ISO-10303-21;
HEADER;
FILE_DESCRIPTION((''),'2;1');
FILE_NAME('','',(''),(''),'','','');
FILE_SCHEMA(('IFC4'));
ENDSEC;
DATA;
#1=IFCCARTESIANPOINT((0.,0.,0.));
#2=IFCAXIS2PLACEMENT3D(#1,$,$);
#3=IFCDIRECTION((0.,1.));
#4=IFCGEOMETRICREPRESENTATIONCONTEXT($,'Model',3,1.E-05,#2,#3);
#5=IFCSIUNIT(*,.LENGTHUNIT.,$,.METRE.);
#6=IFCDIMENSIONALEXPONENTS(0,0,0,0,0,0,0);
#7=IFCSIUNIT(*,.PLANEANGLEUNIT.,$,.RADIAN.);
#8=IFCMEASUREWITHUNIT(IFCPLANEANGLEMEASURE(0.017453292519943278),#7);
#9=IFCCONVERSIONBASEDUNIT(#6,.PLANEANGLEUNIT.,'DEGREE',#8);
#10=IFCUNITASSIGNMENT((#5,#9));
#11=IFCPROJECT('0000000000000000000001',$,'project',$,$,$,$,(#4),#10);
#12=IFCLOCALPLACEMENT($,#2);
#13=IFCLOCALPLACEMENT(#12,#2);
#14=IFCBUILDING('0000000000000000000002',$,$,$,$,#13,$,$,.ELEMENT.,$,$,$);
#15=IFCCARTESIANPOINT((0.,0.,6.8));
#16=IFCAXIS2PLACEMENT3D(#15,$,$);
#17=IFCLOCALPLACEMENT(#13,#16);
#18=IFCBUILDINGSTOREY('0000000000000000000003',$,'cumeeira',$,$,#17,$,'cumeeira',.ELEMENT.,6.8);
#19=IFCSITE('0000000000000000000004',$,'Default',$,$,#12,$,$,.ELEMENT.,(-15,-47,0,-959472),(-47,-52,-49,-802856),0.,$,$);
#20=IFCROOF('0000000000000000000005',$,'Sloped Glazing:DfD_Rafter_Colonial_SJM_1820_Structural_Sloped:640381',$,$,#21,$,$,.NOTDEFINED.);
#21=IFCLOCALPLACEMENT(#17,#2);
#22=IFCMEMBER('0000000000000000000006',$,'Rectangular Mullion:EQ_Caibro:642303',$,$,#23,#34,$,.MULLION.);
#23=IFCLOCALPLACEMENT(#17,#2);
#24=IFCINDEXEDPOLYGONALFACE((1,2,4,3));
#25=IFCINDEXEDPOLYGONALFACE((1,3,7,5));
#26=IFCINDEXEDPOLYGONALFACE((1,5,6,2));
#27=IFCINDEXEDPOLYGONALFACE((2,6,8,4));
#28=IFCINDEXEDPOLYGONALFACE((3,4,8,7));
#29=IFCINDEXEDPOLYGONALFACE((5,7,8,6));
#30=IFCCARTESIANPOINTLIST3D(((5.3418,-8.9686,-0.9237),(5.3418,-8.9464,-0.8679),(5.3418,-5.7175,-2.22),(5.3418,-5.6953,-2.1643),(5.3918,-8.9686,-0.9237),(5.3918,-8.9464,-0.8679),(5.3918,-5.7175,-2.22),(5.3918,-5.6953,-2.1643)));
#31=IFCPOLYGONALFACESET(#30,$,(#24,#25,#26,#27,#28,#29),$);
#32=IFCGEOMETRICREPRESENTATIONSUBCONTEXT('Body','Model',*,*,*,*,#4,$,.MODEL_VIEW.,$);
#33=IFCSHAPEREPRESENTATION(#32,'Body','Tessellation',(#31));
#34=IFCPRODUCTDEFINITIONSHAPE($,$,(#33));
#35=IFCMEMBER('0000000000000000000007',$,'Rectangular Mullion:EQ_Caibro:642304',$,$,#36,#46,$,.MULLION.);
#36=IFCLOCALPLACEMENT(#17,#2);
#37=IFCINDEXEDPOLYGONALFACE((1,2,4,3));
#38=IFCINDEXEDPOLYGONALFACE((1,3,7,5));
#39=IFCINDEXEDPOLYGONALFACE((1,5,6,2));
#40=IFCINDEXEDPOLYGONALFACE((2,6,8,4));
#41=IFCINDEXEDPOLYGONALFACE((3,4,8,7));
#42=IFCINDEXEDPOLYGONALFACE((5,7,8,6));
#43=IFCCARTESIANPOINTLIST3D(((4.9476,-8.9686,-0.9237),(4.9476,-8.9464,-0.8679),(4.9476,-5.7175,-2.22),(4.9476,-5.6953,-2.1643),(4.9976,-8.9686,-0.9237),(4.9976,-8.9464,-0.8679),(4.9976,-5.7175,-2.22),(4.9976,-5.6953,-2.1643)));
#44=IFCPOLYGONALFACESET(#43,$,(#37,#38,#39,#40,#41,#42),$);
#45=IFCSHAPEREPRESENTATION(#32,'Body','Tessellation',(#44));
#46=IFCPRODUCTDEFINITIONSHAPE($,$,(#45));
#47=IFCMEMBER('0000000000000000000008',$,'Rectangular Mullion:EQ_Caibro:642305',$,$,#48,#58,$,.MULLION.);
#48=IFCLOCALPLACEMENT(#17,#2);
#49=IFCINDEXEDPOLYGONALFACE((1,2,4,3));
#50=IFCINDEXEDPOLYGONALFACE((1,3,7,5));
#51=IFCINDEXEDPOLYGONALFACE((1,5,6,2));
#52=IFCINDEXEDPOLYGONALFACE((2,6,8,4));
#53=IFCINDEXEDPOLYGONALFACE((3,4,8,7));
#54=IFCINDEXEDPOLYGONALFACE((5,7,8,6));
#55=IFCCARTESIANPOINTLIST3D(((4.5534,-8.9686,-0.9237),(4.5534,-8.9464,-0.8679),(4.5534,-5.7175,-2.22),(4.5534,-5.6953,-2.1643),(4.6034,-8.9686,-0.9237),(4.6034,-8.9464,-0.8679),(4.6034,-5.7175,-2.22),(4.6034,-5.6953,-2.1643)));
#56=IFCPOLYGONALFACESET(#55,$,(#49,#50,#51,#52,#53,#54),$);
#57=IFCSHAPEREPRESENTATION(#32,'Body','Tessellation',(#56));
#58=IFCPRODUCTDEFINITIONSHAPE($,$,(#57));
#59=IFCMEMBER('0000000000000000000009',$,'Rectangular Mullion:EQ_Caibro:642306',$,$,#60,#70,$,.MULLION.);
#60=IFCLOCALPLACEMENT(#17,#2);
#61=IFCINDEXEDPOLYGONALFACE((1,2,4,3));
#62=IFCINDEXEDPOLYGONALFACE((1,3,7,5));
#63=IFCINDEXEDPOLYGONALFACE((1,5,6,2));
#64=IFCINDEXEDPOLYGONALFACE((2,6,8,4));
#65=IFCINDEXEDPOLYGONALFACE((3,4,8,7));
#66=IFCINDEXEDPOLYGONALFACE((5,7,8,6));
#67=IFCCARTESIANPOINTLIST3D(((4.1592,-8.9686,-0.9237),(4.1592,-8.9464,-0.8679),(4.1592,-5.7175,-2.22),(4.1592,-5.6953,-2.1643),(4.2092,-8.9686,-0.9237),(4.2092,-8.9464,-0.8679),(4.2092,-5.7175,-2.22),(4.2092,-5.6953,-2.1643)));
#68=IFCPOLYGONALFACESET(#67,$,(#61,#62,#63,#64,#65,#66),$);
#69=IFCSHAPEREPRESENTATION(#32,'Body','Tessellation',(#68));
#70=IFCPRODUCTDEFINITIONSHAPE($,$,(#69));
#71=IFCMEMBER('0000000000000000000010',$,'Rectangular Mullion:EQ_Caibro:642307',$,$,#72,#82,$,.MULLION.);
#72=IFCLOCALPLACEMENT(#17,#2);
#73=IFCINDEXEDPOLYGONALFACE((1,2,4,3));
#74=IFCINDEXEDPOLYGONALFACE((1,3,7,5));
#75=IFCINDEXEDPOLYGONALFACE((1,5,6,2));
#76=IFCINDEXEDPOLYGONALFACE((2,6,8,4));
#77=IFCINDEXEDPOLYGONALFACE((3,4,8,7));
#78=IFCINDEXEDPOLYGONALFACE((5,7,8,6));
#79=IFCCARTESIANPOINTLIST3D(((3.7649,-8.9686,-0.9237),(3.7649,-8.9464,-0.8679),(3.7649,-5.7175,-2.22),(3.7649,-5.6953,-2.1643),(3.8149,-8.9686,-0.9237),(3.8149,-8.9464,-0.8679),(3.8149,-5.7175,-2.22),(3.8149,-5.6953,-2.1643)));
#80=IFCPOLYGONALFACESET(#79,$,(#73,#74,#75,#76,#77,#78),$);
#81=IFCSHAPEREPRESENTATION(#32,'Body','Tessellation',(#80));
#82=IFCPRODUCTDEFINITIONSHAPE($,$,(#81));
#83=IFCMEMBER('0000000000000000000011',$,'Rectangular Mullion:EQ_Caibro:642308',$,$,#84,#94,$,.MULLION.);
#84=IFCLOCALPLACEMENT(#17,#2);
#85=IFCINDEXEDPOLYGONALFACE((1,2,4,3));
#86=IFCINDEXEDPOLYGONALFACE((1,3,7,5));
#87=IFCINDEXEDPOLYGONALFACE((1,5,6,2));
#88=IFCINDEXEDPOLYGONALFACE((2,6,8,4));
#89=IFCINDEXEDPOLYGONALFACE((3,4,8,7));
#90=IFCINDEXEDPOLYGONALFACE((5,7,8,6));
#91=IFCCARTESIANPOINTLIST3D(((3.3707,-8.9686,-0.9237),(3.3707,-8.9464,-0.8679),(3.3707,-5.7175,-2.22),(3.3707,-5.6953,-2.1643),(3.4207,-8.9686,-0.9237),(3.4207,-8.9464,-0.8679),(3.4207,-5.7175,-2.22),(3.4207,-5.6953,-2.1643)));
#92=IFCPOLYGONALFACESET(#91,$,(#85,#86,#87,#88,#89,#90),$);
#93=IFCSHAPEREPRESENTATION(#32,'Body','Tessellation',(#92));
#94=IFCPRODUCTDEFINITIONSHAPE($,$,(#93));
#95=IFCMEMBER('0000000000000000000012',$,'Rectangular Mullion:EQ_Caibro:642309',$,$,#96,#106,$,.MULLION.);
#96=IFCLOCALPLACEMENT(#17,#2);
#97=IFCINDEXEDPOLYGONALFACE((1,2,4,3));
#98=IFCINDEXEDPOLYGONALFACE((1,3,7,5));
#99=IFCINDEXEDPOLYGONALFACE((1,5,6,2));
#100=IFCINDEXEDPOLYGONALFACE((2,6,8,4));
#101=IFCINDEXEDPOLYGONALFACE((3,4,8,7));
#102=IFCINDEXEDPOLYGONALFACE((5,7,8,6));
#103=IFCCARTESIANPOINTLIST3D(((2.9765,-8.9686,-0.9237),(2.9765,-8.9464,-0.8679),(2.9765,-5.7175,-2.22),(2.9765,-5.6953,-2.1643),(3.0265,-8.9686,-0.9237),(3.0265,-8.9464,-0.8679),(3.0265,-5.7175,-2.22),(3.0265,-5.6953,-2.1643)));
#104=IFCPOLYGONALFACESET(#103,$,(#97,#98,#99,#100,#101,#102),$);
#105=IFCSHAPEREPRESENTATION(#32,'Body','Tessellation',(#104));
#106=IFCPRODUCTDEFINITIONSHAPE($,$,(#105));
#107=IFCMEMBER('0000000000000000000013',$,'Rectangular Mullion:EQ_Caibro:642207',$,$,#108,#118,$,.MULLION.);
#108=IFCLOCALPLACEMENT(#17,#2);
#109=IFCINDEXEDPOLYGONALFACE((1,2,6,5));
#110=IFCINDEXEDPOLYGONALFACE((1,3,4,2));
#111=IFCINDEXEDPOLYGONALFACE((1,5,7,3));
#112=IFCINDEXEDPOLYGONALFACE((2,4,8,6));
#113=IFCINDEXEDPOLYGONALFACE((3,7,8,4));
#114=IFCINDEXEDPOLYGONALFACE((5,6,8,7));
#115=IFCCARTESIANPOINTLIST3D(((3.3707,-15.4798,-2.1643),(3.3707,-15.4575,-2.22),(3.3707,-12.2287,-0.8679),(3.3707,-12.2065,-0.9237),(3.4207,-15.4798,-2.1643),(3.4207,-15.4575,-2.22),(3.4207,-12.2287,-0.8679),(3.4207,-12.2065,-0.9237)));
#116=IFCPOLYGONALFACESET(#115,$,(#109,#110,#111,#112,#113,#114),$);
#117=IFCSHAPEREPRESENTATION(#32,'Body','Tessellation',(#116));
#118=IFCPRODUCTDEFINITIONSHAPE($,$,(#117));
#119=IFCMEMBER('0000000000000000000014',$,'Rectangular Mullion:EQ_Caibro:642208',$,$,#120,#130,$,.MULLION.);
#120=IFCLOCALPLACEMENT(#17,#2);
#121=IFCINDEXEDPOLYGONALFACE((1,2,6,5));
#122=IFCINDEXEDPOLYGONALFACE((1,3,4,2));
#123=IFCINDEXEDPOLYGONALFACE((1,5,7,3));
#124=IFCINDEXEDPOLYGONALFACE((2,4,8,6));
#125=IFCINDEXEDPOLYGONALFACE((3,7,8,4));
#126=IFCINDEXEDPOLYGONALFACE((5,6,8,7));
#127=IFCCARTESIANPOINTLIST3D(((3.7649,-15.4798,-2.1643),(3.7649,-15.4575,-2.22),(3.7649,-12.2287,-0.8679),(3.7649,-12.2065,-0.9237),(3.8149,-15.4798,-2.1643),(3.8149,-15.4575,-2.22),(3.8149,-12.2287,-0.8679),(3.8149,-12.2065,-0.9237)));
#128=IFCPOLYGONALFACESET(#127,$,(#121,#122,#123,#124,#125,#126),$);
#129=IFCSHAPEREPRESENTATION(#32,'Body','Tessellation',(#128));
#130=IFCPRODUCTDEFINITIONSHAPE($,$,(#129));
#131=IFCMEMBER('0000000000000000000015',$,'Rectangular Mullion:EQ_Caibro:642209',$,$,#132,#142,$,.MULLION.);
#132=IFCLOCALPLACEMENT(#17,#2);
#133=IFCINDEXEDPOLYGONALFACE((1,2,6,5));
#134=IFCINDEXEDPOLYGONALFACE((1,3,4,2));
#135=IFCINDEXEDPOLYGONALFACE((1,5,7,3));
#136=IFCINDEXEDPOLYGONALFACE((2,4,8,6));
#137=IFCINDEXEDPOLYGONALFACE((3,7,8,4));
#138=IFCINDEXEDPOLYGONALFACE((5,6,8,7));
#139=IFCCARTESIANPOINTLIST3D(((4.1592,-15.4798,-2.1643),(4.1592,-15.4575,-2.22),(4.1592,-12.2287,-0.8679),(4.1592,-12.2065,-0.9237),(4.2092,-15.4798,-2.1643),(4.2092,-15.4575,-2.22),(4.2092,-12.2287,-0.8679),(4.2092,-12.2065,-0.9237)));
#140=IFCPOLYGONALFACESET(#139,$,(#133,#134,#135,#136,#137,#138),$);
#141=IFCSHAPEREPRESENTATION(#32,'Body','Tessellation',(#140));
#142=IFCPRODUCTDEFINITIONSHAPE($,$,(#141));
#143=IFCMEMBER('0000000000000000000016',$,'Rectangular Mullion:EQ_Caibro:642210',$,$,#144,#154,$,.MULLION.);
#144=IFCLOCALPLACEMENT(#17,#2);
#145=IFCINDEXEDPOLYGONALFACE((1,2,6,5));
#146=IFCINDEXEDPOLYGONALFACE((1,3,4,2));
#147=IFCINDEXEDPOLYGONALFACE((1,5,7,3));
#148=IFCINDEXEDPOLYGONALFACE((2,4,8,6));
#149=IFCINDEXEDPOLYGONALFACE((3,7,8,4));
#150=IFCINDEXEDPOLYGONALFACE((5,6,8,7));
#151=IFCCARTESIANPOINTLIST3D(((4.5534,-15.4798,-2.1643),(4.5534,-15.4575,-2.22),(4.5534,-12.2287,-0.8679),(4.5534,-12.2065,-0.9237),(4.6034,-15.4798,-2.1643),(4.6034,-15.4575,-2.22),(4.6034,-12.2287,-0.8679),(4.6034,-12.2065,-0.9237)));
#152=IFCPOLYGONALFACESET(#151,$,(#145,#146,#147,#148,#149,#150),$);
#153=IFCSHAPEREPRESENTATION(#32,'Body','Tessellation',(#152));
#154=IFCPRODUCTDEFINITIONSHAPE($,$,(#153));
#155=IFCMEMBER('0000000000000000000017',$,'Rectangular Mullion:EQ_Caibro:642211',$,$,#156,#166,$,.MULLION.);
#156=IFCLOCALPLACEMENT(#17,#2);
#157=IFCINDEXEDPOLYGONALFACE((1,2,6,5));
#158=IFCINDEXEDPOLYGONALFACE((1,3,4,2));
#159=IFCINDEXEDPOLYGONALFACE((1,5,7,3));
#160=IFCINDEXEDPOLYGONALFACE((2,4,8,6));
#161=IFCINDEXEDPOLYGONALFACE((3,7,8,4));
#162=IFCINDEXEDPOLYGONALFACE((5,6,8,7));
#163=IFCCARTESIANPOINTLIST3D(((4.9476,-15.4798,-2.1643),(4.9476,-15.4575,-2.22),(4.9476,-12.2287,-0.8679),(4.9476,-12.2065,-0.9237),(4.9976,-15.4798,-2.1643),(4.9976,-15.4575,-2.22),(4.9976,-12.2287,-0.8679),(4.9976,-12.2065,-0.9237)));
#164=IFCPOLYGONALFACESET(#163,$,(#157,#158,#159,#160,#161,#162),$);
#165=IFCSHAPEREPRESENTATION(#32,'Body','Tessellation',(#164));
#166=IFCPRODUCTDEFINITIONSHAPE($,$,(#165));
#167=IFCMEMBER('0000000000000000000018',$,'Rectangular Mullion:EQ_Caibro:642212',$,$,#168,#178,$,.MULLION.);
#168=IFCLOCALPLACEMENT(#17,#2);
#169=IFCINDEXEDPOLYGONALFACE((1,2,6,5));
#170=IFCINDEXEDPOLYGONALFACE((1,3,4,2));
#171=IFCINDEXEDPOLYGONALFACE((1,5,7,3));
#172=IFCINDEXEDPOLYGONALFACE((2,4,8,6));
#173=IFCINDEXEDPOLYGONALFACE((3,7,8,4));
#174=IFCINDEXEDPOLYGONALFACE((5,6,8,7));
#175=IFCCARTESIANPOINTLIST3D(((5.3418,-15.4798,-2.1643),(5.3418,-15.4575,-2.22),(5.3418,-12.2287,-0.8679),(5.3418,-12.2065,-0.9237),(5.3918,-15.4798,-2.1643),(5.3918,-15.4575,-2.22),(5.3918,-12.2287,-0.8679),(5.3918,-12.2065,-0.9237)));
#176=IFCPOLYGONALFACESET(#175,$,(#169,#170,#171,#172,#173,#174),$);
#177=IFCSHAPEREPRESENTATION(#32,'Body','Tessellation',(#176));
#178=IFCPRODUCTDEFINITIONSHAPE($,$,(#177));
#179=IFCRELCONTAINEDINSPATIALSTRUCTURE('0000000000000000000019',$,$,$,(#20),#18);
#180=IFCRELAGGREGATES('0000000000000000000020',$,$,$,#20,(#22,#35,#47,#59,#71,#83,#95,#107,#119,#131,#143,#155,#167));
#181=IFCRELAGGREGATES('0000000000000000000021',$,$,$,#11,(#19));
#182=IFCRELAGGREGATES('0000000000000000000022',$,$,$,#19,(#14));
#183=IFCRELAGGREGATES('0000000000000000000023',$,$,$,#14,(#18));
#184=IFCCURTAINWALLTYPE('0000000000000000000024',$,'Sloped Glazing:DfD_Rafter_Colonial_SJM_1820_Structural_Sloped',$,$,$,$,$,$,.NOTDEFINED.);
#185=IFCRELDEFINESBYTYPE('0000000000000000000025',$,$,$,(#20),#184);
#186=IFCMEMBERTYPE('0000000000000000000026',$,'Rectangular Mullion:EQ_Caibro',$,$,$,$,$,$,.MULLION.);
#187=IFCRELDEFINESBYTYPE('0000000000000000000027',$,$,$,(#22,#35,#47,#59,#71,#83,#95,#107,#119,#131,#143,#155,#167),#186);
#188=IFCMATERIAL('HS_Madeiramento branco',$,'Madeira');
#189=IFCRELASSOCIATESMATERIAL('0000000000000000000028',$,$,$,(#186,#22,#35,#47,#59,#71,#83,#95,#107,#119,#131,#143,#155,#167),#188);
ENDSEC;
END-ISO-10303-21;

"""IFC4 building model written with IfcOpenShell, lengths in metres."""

from ifc_helpers import new_model, entity, si_unit, converted_unit, direction, frame, origin, place, context, subcontext, project, spatial, indexed_curve, outline, extrude, source, transform, mapped, material, type_object, type_shapes, element, aggregate, save


model = new_model("IFC4")

# Units and contexts
model_context = context("Model", 3, precision=1e-05, world=origin(), true_north=direction((0.0, 1.0)))
body_context = subcontext(model_context, "Body", "Model", "MODEL_VIEW")
ifc_project = project(units=[si_unit("LENGTHUNIT", "METRE"), converted_unit("PLANEANGLEUNIT", "DEGREE", entity("IfcPlaneAngleMeasure", 0.017453292519943278), si_unit("PLANEANGLEUNIT", "RADIAN"), dimensions=[0, 0, 0, 0, 0, 0, 0])], contexts=[model_context])

# Site, building, storey
site_placement = place(None, origin())
site = spatial("IfcSite", under=ifc_project, at=site_placement, Name="Default", CompositionType="ELEMENT", RefLatitude=(-15, -47, 0, -959472), RefLongitude=(-47, -52, -49, -802856), RefElevation=0.0)
building_placement = place(site_placement, origin())
building = spatial("IfcBuilding", under=site, at=building_placement, CompositionType="ELEMENT")
storey_placement = place(building_placement, frame((0.0, 0.0, 6.8)))
storey = spatial("IfcBuildingStorey", under=building, at=storey_placement, Name="cumeeira", LongName="cumeeira", CompositionType="ELEMENT", Elevation=6.8)

# Roof, members
curtain_wall_type = type_object("IfcCurtainWallType", Name="Sloped Glazing:DfD_Rafter_Colonial_SJM_1820_Structural_Sloped", PredefinedType="NOTDEFINED")
roof_placement = place(storey_placement, frame((0.0, 0.0, -6.8)))
roof = element("IfcRoof", 1, at=roof_placement, inside=storey, type_object=curtain_wall_type, Name="Sloped Glazing:DfD_Rafter_Colonial_SJM_1820_Structural_Sloped:640381", PredefinedType="NOTDEFINED")
ifc_material = material(Name="HS_Madeiramento branco", Category="Madeira")
member_type_1 = type_object("IfcMemberType", Name="Rectangular Mullion:EQ_Caibro", PredefinedType="MULLION", material=ifc_material)
shared_shape_1 = source(origin(), body_context, "Body", "SweptSolid", [
    extrude(outline(indexed_curve([(-0.025, -0.03), (0.025, -0.03), (0.025, 0.03), (-0.025, 0.03), (-0.025, -0.03)], self_intersect=False)), frame((0.0, -0.03, -3.5), z_axis=(0.0, 0.0, 1.0), x_axis=(-1.0, 0.0, 0.0)), (0.0, 0.0, 1.0), 3.5),
])
type_shapes(member_type_1, [shared_shape_1])
member_1_placement = place(roof_placement, frame((5.3668, -8.9686, 5.8763), z_axis=(0.0, -0.928878, 0.370385), x_axis=(-1.0, 0.0, 0.0)))
member_1 = element("IfcMember", 2, at=member_1_placement, type_object=member_type_1, material=ifc_material, Name="Rectangular Mullion:EQ_Caibro:642303", PredefinedType="MULLION", context=body_context, shape_type="MappedRepresentation", body=[
    mapped(shared_shape_1, transform((0.0, 0.0, 0.0), scale=1.0)),
])
member_2_placement = place(roof_placement, frame((4.9726, -8.9686, 5.8763), z_axis=(0.0, -0.928878, 0.370385), x_axis=(-1.0, 0.0, 0.0)))
member_2 = element("IfcMember", 3, at=member_2_placement, type_object=member_type_1, material=ifc_material, Name="Rectangular Mullion:EQ_Caibro:642304", PredefinedType="MULLION", context=body_context, shape_type="MappedRepresentation", body=[
    mapped(shared_shape_1, transform((0.0, 0.0, 0.0), scale=1.0)),
])
member_3_placement = place(roof_placement, frame((4.5784, -8.9686, 5.8763), z_axis=(0.0, -0.928878, 0.370385), x_axis=(-1.0, 0.0, 0.0)))
member_3 = element("IfcMember", 4, at=member_3_placement, type_object=member_type_1, material=ifc_material, Name="Rectangular Mullion:EQ_Caibro:642305", PredefinedType="MULLION", context=body_context, shape_type="MappedRepresentation", body=[
    mapped(shared_shape_1, transform((0.0, 0.0, 0.0), scale=1.0)),
])
member_4_placement = place(roof_placement, frame((4.1842, -8.9686, 5.8763), z_axis=(0.0, -0.928878, 0.370385), x_axis=(-1.0, 0.0, 0.0)))
member_4 = element("IfcMember", 5, at=member_4_placement, type_object=member_type_1, material=ifc_material, Name="Rectangular Mullion:EQ_Caibro:642306", PredefinedType="MULLION", context=body_context, shape_type="MappedRepresentation", body=[
    mapped(shared_shape_1, transform((0.0, 0.0, 0.0), scale=1.0)),
])
member_5_placement = place(roof_placement, frame((3.7899, -8.9686, 5.8763), z_axis=(0.0, -0.928878, 0.370385), x_axis=(-1.0, 0.0, 0.0)))
member_5 = element("IfcMember", 6, at=member_5_placement, type_object=member_type_1, material=ifc_material, Name="Rectangular Mullion:EQ_Caibro:642307", PredefinedType="MULLION", context=body_context, shape_type="MappedRepresentation", body=[
    mapped(shared_shape_1, transform((0.0, 0.0, 0.0), scale=1.0)),
])
member_6_placement = place(roof_placement, frame((3.3957, -8.9686, 5.8763), z_axis=(0.0, -0.928878, 0.370385), x_axis=(-1.0, 0.0, 0.0)))
member_6 = element("IfcMember", 7, at=member_6_placement, type_object=member_type_1, material=ifc_material, Name="Rectangular Mullion:EQ_Caibro:642308", PredefinedType="MULLION", context=body_context, shape_type="MappedRepresentation", body=[
    mapped(shared_shape_1, transform((0.0, 0.0, 0.0), scale=1.0)),
])
member_7_placement = place(roof_placement, frame((3.0015, -8.9686, 5.8763), z_axis=(0.0, -0.928878, 0.370385), x_axis=(-1.0, 0.0, 0.0)))
member_7 = element("IfcMember", 8, at=member_7_placement, type_object=member_type_1, material=ifc_material, Name="Rectangular Mullion:EQ_Caibro:642309", PredefinedType="MULLION", context=body_context, shape_type="MappedRepresentation", body=[
    mapped(shared_shape_1, transform((0.0, 0.0, 0.0), scale=1.0)),
])
member_8_placement = place(roof_placement, frame((3.3957, -12.2065, 5.8763), z_axis=(0.0, 0.928878, 0.370385), x_axis=(1.0, 0.0, 0.0)))
member_8 = element("IfcMember", 9, at=member_8_placement, type_object=member_type_1, material=ifc_material, Name="Rectangular Mullion:EQ_Caibro:642207", PredefinedType="MULLION", context=body_context, shape_type="MappedRepresentation", body=[
    mapped(shared_shape_1, transform((0.0, 0.0, 0.0), scale=1.0)),
])
member_9_placement = place(roof_placement, frame((3.7899, -12.2065, 5.8763), z_axis=(0.0, 0.928878, 0.370385), x_axis=(1.0, 0.0, 0.0)))
member_9 = element("IfcMember", 10, at=member_9_placement, type_object=member_type_1, material=ifc_material, Name="Rectangular Mullion:EQ_Caibro:642208", PredefinedType="MULLION", context=body_context, shape_type="MappedRepresentation", body=[
    mapped(shared_shape_1, transform((0.0, 0.0, 0.0), scale=1.0)),
])
member_10_placement = place(roof_placement, frame((4.1842, -12.2065, 5.8763), z_axis=(0.0, 0.928878, 0.370385), x_axis=(1.0, 0.0, 0.0)))
member_10 = element("IfcMember", 11, at=member_10_placement, type_object=member_type_1, material=ifc_material, Name="Rectangular Mullion:EQ_Caibro:642209", PredefinedType="MULLION", context=body_context, shape_type="MappedRepresentation", body=[
    mapped(shared_shape_1, transform((0.0, 0.0, 0.0), scale=1.0)),
])
member_11_placement = place(roof_placement, frame((4.5784, -12.2065, 5.8763), z_axis=(0.0, 0.928878, 0.370385), x_axis=(1.0, 0.0, 0.0)))
member_11 = element("IfcMember", 12, at=member_11_placement, type_object=member_type_1, material=ifc_material, Name="Rectangular Mullion:EQ_Caibro:642210", PredefinedType="MULLION", context=body_context, shape_type="MappedRepresentation", body=[
    mapped(shared_shape_1, transform((0.0, 0.0, 0.0), scale=1.0)),
])
member_12_placement = place(roof_placement, frame((4.9726, -12.2065, 5.8763), z_axis=(0.0, 0.928878, 0.370385), x_axis=(1.0, 0.0, 0.0)))
member_12 = element("IfcMember", 13, at=member_12_placement, type_object=member_type_1, material=ifc_material, Name="Rectangular Mullion:EQ_Caibro:642211", PredefinedType="MULLION", context=body_context, shape_type="MappedRepresentation", body=[
    mapped(shared_shape_1, transform((0.0, 0.0, 0.0), scale=1.0)),
])
member_13_placement = place(roof_placement, frame((5.3668, -12.2065, 5.8763), z_axis=(0.0, 0.928878, 0.370385), x_axis=(1.0, 0.0, 0.0)))
member_13 = element("IfcMember", 14, at=member_13_placement, type_object=member_type_1, material=ifc_material, Name="Rectangular Mullion:EQ_Caibro:642212", PredefinedType="MULLION", context=body_context, shape_type="MappedRepresentation", body=[
    mapped(shared_shape_1, transform((0.0, 0.0, 0.0), scale=1.0)),
])
aggregate(roof, [member_1, member_2, member_3, member_4, member_5, member_6, member_7, member_8, member_9, member_10, member_11, member_12, member_13])

save(model, "model.ifc")
